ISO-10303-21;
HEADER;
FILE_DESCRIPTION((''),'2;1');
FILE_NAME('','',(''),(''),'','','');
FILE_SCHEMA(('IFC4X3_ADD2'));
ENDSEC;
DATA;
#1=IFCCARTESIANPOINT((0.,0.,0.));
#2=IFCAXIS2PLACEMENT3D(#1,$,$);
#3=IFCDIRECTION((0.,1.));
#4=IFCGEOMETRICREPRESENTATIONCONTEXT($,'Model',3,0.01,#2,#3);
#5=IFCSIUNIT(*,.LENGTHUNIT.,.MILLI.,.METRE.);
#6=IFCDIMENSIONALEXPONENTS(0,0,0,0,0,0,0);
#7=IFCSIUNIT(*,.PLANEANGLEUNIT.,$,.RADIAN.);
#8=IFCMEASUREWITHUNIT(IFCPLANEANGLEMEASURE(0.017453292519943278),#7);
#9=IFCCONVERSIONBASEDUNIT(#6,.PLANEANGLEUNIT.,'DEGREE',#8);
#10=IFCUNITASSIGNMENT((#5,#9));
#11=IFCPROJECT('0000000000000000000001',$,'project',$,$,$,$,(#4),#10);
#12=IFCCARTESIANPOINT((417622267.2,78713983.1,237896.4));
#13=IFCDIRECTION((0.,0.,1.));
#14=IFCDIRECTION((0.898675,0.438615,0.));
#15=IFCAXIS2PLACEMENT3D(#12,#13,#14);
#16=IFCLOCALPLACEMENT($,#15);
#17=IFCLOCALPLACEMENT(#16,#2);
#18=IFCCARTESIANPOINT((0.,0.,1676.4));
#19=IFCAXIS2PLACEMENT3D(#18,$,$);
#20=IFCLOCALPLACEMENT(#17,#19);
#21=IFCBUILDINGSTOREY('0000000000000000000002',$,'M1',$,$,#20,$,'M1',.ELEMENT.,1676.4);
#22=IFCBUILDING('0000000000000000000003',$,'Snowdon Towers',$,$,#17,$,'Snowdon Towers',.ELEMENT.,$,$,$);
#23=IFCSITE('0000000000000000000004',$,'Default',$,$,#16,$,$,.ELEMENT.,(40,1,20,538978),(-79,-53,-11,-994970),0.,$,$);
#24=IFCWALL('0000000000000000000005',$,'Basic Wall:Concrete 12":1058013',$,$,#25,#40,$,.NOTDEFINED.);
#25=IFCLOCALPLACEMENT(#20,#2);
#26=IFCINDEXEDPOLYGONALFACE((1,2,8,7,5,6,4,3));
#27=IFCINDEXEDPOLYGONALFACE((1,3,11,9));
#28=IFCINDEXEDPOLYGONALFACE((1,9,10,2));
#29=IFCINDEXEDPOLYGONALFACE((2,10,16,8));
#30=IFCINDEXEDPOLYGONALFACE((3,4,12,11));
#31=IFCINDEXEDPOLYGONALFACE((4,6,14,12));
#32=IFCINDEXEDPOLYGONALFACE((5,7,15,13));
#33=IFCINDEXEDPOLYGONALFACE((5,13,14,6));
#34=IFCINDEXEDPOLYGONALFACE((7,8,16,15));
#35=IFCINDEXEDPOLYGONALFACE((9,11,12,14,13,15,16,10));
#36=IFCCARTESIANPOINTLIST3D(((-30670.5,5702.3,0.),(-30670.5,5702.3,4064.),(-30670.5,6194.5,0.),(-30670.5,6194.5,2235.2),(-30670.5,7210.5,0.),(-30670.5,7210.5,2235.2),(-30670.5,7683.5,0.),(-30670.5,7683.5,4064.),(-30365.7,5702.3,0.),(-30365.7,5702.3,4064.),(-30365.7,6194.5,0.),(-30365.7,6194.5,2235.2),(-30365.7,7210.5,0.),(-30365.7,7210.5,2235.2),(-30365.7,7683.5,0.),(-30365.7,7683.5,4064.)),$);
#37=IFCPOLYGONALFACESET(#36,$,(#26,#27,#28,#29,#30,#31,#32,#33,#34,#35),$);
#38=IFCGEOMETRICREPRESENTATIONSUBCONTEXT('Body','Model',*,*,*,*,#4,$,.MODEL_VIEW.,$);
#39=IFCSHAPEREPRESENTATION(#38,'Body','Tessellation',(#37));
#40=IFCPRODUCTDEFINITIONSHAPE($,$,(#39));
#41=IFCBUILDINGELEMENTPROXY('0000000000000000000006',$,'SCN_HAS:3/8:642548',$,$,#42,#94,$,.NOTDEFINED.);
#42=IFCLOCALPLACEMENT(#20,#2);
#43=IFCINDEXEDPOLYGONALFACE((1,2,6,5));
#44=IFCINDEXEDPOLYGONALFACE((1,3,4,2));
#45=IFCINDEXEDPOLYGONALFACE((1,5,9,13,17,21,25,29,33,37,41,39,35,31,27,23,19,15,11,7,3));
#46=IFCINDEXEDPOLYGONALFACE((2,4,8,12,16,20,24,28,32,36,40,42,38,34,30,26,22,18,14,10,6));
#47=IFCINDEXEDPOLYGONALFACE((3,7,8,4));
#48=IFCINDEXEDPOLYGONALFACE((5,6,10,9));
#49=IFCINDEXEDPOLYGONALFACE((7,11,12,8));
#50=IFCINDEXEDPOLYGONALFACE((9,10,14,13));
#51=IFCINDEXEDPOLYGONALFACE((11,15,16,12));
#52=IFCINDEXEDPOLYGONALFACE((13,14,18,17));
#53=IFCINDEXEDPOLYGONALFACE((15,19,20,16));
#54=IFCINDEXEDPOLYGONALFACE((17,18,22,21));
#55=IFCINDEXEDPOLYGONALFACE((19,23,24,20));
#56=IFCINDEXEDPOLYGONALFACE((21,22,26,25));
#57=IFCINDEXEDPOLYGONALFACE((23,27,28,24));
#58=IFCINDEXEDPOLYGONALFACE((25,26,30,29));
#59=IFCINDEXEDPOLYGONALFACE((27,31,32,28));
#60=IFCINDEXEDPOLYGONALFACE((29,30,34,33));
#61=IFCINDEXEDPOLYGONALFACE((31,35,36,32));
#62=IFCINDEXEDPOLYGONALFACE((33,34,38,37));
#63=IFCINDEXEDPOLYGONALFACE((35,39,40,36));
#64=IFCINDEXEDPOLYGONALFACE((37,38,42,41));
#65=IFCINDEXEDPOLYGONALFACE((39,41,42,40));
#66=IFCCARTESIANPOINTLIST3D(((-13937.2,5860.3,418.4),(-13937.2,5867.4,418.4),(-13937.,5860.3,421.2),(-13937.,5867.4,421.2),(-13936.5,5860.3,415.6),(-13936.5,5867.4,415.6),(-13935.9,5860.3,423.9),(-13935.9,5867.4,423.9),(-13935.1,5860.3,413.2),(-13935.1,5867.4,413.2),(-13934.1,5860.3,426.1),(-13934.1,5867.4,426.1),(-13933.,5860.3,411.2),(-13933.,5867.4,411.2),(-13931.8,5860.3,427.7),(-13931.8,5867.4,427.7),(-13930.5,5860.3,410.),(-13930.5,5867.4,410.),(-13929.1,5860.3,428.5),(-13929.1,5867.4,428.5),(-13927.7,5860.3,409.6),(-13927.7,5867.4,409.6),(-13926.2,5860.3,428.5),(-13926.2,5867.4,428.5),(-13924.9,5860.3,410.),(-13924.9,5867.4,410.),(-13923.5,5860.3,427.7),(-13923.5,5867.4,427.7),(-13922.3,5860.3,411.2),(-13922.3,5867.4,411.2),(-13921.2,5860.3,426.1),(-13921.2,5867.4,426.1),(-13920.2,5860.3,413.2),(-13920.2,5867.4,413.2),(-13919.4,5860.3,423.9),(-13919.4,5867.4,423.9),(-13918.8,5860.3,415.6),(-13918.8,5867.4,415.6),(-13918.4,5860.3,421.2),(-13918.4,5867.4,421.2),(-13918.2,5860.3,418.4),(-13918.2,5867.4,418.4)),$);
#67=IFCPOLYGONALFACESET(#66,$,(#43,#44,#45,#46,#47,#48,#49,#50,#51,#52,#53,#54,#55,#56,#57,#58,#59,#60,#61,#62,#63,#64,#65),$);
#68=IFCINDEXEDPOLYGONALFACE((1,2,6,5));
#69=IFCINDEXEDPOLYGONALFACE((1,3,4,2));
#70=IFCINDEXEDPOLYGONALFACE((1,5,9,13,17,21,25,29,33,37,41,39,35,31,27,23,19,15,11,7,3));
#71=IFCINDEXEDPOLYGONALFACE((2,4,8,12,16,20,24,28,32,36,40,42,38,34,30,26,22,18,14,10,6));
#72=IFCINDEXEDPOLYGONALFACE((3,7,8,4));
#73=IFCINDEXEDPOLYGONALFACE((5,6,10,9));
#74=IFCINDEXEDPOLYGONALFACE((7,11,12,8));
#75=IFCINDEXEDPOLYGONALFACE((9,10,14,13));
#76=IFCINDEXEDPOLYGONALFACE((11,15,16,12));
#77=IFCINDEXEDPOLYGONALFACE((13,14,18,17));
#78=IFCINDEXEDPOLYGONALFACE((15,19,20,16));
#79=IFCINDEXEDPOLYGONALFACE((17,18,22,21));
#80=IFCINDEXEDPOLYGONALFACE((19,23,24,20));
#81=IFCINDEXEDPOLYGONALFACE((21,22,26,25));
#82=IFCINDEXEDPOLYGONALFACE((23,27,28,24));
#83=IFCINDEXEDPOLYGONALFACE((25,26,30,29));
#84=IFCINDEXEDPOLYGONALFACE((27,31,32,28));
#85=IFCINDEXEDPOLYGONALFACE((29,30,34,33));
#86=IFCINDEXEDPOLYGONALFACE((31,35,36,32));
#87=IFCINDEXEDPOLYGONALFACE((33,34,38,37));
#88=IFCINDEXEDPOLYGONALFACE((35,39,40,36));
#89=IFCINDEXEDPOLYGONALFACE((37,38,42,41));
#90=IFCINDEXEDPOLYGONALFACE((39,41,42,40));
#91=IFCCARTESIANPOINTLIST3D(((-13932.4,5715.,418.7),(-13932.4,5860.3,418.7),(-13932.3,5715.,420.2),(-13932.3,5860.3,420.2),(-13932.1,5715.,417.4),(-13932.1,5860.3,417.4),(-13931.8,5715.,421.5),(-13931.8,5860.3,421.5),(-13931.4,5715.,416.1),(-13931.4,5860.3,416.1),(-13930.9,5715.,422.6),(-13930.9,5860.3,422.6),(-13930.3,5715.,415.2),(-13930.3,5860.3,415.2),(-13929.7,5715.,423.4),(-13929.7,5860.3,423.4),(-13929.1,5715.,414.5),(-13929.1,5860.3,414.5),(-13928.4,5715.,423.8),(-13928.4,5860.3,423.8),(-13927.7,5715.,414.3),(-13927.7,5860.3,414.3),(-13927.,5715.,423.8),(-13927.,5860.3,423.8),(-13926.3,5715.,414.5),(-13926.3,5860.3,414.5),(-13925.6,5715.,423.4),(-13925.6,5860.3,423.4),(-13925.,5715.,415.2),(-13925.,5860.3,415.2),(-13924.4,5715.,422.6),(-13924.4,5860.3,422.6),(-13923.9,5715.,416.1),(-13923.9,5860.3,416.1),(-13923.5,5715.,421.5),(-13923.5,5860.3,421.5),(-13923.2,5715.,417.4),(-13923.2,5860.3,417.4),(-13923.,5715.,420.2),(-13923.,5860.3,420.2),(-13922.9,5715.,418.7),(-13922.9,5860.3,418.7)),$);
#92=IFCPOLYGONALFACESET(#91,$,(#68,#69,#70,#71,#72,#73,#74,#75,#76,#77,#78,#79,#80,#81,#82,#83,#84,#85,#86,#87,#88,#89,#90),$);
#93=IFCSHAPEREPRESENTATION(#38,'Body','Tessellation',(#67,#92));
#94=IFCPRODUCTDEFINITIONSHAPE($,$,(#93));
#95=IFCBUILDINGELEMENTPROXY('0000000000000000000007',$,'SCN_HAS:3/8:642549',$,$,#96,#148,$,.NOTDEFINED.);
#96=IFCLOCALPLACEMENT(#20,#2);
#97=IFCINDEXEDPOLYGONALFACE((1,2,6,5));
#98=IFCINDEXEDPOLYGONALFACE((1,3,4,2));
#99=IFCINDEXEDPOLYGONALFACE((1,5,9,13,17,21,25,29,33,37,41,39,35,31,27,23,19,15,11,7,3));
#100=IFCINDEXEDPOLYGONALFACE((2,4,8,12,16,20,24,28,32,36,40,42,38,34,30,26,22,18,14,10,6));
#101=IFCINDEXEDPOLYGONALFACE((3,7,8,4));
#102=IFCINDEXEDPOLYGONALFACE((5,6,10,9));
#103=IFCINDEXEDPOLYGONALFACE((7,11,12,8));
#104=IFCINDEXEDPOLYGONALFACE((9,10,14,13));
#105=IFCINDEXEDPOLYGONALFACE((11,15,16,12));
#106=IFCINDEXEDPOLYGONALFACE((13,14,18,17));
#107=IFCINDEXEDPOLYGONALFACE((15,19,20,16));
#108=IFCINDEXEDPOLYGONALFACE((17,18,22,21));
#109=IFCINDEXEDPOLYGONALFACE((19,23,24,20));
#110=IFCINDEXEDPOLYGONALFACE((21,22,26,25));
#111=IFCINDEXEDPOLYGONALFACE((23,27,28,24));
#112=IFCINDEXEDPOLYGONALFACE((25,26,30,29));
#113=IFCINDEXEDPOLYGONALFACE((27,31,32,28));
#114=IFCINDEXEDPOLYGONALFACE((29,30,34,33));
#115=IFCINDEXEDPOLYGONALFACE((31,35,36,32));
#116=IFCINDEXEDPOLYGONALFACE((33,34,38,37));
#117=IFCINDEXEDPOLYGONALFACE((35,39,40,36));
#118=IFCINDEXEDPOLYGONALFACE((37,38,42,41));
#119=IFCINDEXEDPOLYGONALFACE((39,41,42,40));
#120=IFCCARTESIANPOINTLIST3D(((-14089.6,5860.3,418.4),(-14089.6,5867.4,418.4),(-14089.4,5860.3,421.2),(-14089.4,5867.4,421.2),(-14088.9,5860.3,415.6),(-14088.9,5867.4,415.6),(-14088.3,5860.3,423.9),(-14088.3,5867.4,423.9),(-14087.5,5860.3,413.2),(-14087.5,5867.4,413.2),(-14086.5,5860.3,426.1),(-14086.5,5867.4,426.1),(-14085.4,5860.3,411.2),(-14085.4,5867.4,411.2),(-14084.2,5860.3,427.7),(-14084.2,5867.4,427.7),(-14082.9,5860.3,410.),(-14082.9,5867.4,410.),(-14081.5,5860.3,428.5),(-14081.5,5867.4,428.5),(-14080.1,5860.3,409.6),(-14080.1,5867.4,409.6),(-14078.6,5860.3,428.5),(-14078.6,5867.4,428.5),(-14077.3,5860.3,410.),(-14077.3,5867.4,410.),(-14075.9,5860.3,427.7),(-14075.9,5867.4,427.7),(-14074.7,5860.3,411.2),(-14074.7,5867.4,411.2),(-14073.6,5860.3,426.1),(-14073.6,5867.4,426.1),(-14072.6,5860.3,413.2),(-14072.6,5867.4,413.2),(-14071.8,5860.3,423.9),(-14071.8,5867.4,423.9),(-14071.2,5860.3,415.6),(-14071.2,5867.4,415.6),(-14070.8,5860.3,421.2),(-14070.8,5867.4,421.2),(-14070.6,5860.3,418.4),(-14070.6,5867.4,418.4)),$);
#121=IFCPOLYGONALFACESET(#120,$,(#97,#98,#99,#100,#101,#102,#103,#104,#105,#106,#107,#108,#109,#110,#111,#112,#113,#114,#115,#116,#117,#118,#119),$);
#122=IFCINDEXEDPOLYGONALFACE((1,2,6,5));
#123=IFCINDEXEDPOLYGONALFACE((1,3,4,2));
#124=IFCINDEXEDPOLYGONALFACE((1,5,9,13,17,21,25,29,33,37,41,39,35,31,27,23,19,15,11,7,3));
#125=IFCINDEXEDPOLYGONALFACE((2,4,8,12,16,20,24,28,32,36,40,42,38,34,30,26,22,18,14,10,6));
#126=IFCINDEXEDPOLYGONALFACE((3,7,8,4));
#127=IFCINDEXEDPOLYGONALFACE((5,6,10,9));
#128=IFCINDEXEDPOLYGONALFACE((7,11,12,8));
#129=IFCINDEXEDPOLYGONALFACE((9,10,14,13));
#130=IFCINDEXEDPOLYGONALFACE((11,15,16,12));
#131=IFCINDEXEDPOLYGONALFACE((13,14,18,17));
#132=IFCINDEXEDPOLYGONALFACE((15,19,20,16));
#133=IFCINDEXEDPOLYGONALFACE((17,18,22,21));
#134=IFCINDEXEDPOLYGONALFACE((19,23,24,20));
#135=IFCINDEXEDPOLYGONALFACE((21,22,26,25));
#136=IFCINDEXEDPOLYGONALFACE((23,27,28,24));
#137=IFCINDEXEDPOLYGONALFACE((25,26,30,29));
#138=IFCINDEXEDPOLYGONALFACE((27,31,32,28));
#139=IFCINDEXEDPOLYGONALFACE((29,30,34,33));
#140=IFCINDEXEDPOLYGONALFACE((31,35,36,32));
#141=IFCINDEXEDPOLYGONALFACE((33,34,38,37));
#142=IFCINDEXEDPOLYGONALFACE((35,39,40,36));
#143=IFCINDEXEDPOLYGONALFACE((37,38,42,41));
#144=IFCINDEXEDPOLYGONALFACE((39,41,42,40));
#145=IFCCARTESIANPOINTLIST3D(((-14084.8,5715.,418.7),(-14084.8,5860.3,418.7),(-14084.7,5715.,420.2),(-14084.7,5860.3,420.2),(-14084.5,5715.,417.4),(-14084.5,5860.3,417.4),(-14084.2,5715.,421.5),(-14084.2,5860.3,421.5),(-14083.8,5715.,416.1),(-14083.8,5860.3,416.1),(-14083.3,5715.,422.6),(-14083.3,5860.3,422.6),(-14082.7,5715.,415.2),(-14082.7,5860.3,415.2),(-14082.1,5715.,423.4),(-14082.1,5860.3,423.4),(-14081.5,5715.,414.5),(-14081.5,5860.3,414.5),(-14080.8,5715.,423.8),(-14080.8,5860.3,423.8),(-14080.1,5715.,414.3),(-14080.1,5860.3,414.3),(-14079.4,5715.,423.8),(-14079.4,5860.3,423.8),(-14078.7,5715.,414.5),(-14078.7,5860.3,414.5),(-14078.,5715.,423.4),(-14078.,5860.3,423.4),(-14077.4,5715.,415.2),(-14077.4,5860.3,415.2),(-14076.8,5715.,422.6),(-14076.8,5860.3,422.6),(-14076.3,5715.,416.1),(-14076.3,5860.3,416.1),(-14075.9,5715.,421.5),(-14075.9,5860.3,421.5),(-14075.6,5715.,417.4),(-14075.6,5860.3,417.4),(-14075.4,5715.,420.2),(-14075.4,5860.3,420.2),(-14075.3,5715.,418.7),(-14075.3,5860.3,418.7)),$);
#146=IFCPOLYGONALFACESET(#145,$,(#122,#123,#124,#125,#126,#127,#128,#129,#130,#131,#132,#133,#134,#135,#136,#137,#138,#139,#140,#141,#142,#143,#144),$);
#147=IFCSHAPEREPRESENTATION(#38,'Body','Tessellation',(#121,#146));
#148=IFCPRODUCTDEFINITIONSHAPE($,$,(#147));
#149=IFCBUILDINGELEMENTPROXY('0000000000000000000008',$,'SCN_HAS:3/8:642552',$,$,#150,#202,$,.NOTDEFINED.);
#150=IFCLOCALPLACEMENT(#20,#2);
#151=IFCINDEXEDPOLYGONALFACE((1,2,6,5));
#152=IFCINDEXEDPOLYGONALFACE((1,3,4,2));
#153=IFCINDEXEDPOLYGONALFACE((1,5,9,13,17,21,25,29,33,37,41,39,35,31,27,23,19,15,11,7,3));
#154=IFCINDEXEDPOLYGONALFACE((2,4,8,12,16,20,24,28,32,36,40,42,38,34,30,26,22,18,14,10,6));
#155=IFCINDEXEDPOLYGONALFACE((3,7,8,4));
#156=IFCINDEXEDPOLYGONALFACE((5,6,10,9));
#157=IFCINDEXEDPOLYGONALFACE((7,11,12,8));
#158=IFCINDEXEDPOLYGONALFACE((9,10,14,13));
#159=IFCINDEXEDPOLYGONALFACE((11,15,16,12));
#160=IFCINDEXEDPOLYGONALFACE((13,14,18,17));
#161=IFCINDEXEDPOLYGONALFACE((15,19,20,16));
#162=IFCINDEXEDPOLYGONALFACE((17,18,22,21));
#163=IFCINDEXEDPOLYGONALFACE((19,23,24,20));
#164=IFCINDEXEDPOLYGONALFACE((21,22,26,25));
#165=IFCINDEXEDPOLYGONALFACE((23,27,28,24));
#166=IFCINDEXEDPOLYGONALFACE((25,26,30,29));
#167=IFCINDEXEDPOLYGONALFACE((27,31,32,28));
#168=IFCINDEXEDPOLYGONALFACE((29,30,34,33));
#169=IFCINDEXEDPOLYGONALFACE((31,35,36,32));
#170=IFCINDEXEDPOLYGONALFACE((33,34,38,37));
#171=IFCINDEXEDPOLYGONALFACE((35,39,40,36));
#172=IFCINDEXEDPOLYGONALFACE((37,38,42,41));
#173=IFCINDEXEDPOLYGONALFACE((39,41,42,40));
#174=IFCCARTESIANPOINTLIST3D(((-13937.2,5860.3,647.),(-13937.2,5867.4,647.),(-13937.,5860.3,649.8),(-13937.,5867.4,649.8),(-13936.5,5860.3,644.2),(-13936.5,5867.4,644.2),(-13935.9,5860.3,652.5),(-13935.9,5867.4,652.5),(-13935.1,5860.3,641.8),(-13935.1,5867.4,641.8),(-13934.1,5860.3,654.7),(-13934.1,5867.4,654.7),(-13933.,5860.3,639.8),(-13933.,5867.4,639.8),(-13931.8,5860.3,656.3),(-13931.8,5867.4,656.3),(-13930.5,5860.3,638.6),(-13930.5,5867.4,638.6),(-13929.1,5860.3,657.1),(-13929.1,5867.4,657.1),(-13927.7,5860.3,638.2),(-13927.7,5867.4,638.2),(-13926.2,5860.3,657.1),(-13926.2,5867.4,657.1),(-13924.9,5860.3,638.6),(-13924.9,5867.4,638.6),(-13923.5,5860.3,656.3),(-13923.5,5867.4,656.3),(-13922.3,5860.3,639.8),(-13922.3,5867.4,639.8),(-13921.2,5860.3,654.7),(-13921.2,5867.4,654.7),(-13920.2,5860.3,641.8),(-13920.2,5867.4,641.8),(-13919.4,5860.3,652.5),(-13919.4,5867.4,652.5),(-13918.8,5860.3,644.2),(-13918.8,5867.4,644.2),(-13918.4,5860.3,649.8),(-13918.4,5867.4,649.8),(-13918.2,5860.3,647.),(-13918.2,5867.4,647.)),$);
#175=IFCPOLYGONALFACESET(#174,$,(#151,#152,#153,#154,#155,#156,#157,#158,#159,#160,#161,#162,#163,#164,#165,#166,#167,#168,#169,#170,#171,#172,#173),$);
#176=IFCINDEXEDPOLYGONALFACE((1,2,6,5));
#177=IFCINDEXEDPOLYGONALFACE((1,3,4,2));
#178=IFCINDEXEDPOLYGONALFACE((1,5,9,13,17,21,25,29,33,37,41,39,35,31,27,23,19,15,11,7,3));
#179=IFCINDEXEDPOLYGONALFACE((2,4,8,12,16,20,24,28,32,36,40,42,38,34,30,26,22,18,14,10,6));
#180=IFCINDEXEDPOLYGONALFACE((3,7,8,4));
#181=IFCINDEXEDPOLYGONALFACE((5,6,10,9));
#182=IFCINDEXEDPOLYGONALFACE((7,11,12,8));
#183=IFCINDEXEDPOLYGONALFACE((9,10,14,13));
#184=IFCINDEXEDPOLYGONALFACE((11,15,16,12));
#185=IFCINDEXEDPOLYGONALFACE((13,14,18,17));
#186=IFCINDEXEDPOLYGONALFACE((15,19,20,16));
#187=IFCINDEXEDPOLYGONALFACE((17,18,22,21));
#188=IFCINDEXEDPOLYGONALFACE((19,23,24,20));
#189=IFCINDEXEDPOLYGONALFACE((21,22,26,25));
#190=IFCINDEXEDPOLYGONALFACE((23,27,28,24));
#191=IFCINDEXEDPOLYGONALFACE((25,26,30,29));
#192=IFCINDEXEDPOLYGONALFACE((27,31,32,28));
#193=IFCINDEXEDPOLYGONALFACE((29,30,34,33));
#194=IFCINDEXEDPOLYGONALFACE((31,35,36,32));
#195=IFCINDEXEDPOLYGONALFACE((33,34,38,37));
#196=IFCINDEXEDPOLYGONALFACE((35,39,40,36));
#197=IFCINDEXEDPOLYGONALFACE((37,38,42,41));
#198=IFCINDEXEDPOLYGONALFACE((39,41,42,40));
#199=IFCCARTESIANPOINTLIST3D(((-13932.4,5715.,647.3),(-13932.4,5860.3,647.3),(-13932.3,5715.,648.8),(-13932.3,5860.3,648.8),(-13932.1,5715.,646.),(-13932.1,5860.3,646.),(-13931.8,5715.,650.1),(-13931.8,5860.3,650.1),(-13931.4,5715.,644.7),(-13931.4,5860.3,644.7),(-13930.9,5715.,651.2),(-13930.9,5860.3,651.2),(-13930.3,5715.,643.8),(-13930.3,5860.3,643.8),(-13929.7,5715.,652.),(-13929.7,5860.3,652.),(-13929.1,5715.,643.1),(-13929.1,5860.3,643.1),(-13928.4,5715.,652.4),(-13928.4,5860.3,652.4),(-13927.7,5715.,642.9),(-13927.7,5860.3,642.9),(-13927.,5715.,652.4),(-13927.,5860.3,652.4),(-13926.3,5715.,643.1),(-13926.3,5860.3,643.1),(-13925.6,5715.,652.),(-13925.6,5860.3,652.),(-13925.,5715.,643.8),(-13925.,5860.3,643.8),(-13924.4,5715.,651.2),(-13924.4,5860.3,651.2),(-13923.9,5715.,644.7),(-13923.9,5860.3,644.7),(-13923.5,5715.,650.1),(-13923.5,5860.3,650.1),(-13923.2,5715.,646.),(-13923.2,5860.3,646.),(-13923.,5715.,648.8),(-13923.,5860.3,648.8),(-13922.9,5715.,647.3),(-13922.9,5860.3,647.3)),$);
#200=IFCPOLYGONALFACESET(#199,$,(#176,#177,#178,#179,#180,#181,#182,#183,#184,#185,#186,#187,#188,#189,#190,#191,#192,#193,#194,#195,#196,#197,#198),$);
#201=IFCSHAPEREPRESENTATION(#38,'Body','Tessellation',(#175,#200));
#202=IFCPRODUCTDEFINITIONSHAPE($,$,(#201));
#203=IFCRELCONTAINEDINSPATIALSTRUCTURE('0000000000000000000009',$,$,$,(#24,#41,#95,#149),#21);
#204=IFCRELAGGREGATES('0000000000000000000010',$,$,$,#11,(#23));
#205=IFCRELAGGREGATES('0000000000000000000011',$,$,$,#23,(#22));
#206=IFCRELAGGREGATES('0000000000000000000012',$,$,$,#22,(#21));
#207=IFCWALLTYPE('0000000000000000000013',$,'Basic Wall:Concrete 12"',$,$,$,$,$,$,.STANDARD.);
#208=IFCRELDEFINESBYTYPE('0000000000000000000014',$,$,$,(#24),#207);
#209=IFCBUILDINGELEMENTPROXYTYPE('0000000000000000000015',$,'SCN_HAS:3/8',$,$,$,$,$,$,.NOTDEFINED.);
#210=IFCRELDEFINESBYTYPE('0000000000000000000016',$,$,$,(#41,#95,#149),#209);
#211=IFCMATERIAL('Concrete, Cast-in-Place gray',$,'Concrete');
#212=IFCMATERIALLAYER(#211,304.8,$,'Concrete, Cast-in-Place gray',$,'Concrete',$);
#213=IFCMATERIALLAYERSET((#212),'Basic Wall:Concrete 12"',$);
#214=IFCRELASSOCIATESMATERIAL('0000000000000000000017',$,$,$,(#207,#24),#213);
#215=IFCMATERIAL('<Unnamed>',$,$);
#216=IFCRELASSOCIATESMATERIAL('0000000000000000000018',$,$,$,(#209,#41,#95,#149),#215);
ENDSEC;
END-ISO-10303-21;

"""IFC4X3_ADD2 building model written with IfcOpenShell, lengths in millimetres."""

from ifc_helpers import new_model, entity, si_unit, converted_unit, direction, frame, frame_2d, origin, place, context, subcontext, project, spatial, rectangle, circle, extrude, source, transform, mapped, material, layer, layer_set, type_object, type_shapes, element, save


model = new_model("IFC4X3_ADD2")

# Units and contexts
model_context = context("Model", 3, precision=0.01, world=origin(), true_north=direction((0.0, 1.0)))
body_context = subcontext(model_context, "Body", "Model", "MODEL_VIEW")
ifc_project = project(units=[si_unit("LENGTHUNIT", "METRE", prefix="MILLI"), converted_unit("PLANEANGLEUNIT", "DEGREE", entity("IfcPlaneAngleMeasure", 0.017453292519943278), si_unit("PLANEANGLEUNIT", "RADIAN"), dimensions=[0, 0, 0, 0, 0, 0, 0])], contexts=[model_context])

# Site, building, storey
site_placement = place(None, frame((417622267.2, 78713983.1, 237896.4), z_axis=(0.0, 0.0, 1.0), x_axis=(0.898675, 0.438615, 0.0)))
site = spatial("IfcSite", under=ifc_project, at=site_placement, Name="Default", CompositionType="ELEMENT", RefLatitude=(40, 1, 20, 538978), RefLongitude=(-79, -53, -11, -994970), RefElevation=0.0)
building_placement = place(site_placement, origin())
building = spatial("IfcBuilding", under=site, at=building_placement, Name="Snowdon Towers", LongName="Snowdon Towers", CompositionType="ELEMENT")
storey_placement = place(building_placement, frame((0.0, 0.0, 1676.4)))
storey = spatial("IfcBuildingStorey", under=building, at=storey_placement, Name="M1", LongName="M1", CompositionType="ELEMENT", Elevation=1676.4)

# Shared definitions
ifc_material_1 = material(Name="Concrete, Cast-in-Place gray", Category="Concrete")
ifc_layer_1 = layer(ifc_material_1, 304.8, Name="Concrete, Cast-in-Place gray", Category="Concrete")
ifc_layer_set_1 = layer_set([ifc_layer_1], Name="Basic Wall:Concrete 12\"")
wall_type_1 = type_object("IfcWallType", Name="Basic Wall:Concrete 12\"", PredefinedType="STANDARD", material=ifc_layer_set_1)

# Wall, opening
wall_1_placement = place(storey_placement, frame((-30518.1, 7683.5, 0.0), z_axis=(0.0, 0.0, 1.0), x_axis=(0.0, -1.0, 0.0)))
wall_1 = element("IfcWall", 1, at=wall_1_placement, inside=storey, type_object=wall_type_1, material=ifc_layer_set_1, Name="Basic Wall:Concrete 12\":1058013", PredefinedType="NOTDEFINED", context=body_context, shape_type="SweptSolid", body=[
    extrude(rectangle(XDim=1981.2, YDim=304.8, at=frame_2d((990.6, 0.0), x_axis=(-1.0, 0.0))), origin(), (0.0, 0.0, 1.0), 4064.0),
])
opening_placement = place(wall_1_placement, origin())
element("IfcOpeningElement", 2, at=opening_placement, cuts=wall_1, PredefinedType="OPENING", context=body_context, shape_type="SweptSolid", body=[
    extrude(rectangle(XDim=2235.2, YDim=1016.0, at=frame_2d((0.0, 0.0), x_axis=(0.0, 1.0))), frame((981.0, 152.4, 1117.6), z_axis=(0.0, -1.0, 0.0), x_axis=(1.0, 0.0, 0.0)), (0.0, 0.0, 1.0), 304.8),
])

# Building element proxies
ifc_material_2 = material(Name="<Unnamed>")
building_element_proxy_type = type_object("IfcBuildingElementProxyType", Name="SCN_HAS:3/8", PredefinedType="NOTDEFINED", material=ifc_material_2)
shared_shape_1 = source(origin(), body_context, "Body", "SweptSolid", [
    extrude(circle(Radius=9.5, at=frame_2d((0.0, 0.0), x_axis=(1.0, 0.0))), frame((0.0, 0.0, -152.4), z_axis=(0.0, 0.0, 1.0), x_axis=(0.0, -1.0, 0.0)), (0.0, 0.0, 1.0), 7.1),
    extrude(circle(Radius=4.8, at=frame_2d((0.0, 0.0), x_axis=(1.0, 0.0))), frame((0.0, 0.0, -145.3), z_axis=(0.0, 0.0, 1.0), x_axis=(0.0, -1.0, 0.0)), (0.0, 0.0, 1.0), 145.3),
])
type_shapes(building_element_proxy_type, [shared_shape_1])
for number, where, z_axis, x_axis, name in (
    (3, (-13927.7, 5715.0, 419.1), (0.0, -1.0, 0.0), (1.0, 0.0, 0.0), "SCN_HAS:3/8:642548"),
    (4, (-14080.1, 5715.0, 419.1), (0.0, -1.0, 0.0), (1.0, 0.0, 0.0), "SCN_HAS:3/8:642549"),
    (5, (-13927.7, 5715.0, 647.7), (0.0, -1.0, 0.0), (1.0, 0.0, 0.0), "SCN_HAS:3/8:642552"),
):
    element("IfcBuildingElementProxy", number, at=place(storey_placement, frame(where, z_axis=z_axis, x_axis=x_axis)), inside=storey, type_object=building_element_proxy_type, material=ifc_material_2, Name=name, PredefinedType="NOTDEFINED", context=body_context, shape_type="MappedRepresentation", body=[
        mapped(shared_shape_1, transform((0.0, 0.0, 0.0), scale=1.0)),
    ])

save(model, "model.ifc")
